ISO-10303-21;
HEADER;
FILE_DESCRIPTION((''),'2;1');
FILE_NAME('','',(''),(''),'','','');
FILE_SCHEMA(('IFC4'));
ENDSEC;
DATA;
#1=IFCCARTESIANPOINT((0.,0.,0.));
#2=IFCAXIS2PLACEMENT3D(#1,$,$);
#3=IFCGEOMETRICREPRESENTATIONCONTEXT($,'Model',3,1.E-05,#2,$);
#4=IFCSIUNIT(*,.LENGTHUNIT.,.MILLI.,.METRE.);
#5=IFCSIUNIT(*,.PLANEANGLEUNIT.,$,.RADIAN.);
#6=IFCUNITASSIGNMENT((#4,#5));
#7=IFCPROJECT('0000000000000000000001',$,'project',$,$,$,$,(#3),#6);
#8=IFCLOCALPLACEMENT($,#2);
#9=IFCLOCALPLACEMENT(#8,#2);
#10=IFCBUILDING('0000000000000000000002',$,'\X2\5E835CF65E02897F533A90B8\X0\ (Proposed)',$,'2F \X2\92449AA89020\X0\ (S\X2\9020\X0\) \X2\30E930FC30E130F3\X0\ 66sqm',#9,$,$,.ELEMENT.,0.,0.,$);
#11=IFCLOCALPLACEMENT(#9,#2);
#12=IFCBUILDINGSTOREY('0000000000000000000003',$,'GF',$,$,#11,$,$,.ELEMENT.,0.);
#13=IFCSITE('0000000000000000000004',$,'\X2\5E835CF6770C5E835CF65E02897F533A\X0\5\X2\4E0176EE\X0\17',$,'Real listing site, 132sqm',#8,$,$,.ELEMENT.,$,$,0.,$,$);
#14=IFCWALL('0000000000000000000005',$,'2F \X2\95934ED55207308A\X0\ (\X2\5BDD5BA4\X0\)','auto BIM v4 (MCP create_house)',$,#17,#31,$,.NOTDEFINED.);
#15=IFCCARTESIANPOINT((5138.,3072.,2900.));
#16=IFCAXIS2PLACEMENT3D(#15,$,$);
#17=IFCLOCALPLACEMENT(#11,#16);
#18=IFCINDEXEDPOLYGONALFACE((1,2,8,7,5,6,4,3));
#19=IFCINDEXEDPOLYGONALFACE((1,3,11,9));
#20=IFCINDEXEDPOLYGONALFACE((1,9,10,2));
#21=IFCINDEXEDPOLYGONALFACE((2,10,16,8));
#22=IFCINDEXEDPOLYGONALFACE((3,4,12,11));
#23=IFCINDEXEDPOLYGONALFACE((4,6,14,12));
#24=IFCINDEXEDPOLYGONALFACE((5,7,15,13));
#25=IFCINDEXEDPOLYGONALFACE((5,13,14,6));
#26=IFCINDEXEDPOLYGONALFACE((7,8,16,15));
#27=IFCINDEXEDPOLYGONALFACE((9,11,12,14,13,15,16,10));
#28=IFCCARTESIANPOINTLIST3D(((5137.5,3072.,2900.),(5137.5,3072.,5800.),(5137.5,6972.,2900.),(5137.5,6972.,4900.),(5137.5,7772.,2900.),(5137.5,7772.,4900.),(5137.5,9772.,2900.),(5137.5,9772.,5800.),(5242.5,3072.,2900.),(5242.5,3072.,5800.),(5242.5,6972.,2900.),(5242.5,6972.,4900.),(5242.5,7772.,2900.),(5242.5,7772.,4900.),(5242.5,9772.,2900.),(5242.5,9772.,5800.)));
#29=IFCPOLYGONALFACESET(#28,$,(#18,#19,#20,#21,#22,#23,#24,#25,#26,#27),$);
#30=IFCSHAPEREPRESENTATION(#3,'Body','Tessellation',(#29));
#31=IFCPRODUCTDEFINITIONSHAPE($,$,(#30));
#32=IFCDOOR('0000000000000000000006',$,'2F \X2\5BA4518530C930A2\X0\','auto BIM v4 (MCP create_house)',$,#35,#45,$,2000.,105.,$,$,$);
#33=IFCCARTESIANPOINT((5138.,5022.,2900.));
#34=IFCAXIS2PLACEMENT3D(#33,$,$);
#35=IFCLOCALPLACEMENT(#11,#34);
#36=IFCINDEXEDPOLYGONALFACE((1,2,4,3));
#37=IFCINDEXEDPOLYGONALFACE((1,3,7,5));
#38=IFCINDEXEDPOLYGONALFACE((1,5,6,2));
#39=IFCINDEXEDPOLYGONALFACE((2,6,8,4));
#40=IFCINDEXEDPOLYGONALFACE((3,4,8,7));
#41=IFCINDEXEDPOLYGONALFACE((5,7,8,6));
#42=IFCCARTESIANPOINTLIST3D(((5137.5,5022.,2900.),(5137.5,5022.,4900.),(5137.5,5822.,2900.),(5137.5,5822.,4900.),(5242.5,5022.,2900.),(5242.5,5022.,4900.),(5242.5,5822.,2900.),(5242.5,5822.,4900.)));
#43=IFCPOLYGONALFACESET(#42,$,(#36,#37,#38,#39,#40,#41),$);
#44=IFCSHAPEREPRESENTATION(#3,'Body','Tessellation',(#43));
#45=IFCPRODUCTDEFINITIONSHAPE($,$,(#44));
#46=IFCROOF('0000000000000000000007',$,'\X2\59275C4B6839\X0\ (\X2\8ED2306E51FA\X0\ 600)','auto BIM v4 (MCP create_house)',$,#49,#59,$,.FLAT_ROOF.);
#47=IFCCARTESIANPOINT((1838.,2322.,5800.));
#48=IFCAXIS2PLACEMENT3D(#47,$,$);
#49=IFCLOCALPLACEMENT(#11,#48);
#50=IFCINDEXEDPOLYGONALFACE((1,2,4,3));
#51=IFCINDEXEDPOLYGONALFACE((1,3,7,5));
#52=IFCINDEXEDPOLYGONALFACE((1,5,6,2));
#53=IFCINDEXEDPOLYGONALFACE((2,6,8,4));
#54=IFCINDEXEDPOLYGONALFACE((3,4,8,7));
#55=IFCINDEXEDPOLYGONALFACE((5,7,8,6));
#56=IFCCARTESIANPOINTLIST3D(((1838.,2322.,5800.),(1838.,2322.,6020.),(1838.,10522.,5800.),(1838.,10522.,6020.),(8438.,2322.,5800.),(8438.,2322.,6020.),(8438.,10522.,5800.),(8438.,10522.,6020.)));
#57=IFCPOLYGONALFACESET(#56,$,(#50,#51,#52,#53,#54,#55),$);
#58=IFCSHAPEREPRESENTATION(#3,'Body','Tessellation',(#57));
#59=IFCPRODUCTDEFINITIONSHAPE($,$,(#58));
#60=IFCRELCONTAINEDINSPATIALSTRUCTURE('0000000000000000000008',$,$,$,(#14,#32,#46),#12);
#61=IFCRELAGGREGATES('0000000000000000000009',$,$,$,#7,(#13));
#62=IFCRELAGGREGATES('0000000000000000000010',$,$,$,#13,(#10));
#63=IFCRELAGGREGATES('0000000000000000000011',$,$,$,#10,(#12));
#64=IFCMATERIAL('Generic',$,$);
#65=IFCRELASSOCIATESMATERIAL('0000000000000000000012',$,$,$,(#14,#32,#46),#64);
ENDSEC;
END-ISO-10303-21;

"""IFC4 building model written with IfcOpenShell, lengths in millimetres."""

from ifc_helpers import new_model, si_unit, frame, frame_2d, origin, place, context, project, spatial, rectangle, extrude, material, element, fill, save


model = new_model("IFC4")

# Units and contexts
model_context = context("Model", 3, precision=1e-05, world=origin())
ifc_project = project(units=[si_unit("LENGTHUNIT", "METRE", prefix="MILLI"), si_unit("PLANEANGLEUNIT", "RADIAN")], contexts=[model_context])

# Site, building, storey
site_placement = place(None, origin())
site = spatial("IfcSite", under=ifc_project, at=site_placement, Name="広島県広島市西区5丁目17", ObjectType="Real listing site, 132sqm", CompositionType="ELEMENT", RefElevation=0.0)
building_placement = place(site_placement, origin())
building = spatial("IfcBuilding", under=site, at=building_placement, Name="広島市西区邸 (Proposed)", ObjectType="2F 鉄骨造 (S造) ラーメン 66sqm", CompositionType="ELEMENT", ElevationOfRefHeight=0.0, ElevationOfTerrain=0.0)
storey_placement = place(building_placement, origin())
storey = spatial("IfcBuildingStorey", under=building, at=storey_placement, Name="GF", CompositionType="ELEMENT", Elevation=0.0)

# Shared definitions
ifc_material = material(Name="Generic")

# Wall, opening, door
wall_1_placement = place(storey_placement, frame((5138.0, 3072.0, 2900.0)))
wall_1 = element("IfcWall", 1, at=wall_1_placement, inside=storey, material=ifc_material, Name="2F 間仕切り (寝室)", Description="auto BIM v4 (MCP create_house)", PredefinedType="NOTDEFINED", context=model_context, shape_type="SweptSolid", body=[
    extrude(rectangle(XDim=105.0, YDim=6700.0, at=frame_2d((52.0, 3350.0))), frame((5138.0, 3072.0, 2900.0)), (0.0, 0.0, 1.0), 2900.0),
])
opening_1_placement = place(storey_placement, frame((5138.0, 5022.0, 2900.0)))
opening_1 = element("IfcOpeningElement", 2, at=opening_1_placement, cuts=wall_1, PredefinedType="NOTDEFINED", context=model_context, shape_type="SweptSolid", body=[
    extrude(rectangle(XDim=105.0, YDim=800.0, at=frame_2d((52.0, 400.0))), frame((5138.0, 5022.0, 2900.0)), (0.0, 0.0, 1.0), 2000.0),
])
door_1_placement = place(storey_placement, frame((5138.0, 5022.0, 2900.0)))
door_1 = element("IfcDoor", 3, at=door_1_placement, inside=storey, material=ifc_material, Name="2F 室内ドア", Description="auto BIM v4 (MCP create_house)", OverallHeight=2000.0, OverallWidth=105.0, context=model_context, shape_type="SweptSolid", body=[
    extrude(rectangle(XDim=105.0, YDim=800.0, at=frame_2d((52.0, 400.0))), frame((5138.0, 5022.0, 2900.0)), (0.0, 0.0, 1.0), 2000.0),
])
fill(opening_1, door_1)

# Roof
roof_placement = place(storey_placement, frame((1838.0, 2322.0, 5800.0)))
element("IfcRoof", 4, at=roof_placement, inside=storey, material=ifc_material, Name="大屋根 (軒の出 600)", Description="auto BIM v4 (MCP create_house)", PredefinedType="FLAT_ROOF", context=model_context, shape_type="SweptSolid", body=[
    extrude(rectangle(XDim=6600.0, YDim=8200.0, at=frame_2d((3300.0, 4100.0))), frame((1838.0, 2322.0, 5800.0)), (0.0, 0.0, 1.0), 220.0),
])

save(model, "model.ifc")
